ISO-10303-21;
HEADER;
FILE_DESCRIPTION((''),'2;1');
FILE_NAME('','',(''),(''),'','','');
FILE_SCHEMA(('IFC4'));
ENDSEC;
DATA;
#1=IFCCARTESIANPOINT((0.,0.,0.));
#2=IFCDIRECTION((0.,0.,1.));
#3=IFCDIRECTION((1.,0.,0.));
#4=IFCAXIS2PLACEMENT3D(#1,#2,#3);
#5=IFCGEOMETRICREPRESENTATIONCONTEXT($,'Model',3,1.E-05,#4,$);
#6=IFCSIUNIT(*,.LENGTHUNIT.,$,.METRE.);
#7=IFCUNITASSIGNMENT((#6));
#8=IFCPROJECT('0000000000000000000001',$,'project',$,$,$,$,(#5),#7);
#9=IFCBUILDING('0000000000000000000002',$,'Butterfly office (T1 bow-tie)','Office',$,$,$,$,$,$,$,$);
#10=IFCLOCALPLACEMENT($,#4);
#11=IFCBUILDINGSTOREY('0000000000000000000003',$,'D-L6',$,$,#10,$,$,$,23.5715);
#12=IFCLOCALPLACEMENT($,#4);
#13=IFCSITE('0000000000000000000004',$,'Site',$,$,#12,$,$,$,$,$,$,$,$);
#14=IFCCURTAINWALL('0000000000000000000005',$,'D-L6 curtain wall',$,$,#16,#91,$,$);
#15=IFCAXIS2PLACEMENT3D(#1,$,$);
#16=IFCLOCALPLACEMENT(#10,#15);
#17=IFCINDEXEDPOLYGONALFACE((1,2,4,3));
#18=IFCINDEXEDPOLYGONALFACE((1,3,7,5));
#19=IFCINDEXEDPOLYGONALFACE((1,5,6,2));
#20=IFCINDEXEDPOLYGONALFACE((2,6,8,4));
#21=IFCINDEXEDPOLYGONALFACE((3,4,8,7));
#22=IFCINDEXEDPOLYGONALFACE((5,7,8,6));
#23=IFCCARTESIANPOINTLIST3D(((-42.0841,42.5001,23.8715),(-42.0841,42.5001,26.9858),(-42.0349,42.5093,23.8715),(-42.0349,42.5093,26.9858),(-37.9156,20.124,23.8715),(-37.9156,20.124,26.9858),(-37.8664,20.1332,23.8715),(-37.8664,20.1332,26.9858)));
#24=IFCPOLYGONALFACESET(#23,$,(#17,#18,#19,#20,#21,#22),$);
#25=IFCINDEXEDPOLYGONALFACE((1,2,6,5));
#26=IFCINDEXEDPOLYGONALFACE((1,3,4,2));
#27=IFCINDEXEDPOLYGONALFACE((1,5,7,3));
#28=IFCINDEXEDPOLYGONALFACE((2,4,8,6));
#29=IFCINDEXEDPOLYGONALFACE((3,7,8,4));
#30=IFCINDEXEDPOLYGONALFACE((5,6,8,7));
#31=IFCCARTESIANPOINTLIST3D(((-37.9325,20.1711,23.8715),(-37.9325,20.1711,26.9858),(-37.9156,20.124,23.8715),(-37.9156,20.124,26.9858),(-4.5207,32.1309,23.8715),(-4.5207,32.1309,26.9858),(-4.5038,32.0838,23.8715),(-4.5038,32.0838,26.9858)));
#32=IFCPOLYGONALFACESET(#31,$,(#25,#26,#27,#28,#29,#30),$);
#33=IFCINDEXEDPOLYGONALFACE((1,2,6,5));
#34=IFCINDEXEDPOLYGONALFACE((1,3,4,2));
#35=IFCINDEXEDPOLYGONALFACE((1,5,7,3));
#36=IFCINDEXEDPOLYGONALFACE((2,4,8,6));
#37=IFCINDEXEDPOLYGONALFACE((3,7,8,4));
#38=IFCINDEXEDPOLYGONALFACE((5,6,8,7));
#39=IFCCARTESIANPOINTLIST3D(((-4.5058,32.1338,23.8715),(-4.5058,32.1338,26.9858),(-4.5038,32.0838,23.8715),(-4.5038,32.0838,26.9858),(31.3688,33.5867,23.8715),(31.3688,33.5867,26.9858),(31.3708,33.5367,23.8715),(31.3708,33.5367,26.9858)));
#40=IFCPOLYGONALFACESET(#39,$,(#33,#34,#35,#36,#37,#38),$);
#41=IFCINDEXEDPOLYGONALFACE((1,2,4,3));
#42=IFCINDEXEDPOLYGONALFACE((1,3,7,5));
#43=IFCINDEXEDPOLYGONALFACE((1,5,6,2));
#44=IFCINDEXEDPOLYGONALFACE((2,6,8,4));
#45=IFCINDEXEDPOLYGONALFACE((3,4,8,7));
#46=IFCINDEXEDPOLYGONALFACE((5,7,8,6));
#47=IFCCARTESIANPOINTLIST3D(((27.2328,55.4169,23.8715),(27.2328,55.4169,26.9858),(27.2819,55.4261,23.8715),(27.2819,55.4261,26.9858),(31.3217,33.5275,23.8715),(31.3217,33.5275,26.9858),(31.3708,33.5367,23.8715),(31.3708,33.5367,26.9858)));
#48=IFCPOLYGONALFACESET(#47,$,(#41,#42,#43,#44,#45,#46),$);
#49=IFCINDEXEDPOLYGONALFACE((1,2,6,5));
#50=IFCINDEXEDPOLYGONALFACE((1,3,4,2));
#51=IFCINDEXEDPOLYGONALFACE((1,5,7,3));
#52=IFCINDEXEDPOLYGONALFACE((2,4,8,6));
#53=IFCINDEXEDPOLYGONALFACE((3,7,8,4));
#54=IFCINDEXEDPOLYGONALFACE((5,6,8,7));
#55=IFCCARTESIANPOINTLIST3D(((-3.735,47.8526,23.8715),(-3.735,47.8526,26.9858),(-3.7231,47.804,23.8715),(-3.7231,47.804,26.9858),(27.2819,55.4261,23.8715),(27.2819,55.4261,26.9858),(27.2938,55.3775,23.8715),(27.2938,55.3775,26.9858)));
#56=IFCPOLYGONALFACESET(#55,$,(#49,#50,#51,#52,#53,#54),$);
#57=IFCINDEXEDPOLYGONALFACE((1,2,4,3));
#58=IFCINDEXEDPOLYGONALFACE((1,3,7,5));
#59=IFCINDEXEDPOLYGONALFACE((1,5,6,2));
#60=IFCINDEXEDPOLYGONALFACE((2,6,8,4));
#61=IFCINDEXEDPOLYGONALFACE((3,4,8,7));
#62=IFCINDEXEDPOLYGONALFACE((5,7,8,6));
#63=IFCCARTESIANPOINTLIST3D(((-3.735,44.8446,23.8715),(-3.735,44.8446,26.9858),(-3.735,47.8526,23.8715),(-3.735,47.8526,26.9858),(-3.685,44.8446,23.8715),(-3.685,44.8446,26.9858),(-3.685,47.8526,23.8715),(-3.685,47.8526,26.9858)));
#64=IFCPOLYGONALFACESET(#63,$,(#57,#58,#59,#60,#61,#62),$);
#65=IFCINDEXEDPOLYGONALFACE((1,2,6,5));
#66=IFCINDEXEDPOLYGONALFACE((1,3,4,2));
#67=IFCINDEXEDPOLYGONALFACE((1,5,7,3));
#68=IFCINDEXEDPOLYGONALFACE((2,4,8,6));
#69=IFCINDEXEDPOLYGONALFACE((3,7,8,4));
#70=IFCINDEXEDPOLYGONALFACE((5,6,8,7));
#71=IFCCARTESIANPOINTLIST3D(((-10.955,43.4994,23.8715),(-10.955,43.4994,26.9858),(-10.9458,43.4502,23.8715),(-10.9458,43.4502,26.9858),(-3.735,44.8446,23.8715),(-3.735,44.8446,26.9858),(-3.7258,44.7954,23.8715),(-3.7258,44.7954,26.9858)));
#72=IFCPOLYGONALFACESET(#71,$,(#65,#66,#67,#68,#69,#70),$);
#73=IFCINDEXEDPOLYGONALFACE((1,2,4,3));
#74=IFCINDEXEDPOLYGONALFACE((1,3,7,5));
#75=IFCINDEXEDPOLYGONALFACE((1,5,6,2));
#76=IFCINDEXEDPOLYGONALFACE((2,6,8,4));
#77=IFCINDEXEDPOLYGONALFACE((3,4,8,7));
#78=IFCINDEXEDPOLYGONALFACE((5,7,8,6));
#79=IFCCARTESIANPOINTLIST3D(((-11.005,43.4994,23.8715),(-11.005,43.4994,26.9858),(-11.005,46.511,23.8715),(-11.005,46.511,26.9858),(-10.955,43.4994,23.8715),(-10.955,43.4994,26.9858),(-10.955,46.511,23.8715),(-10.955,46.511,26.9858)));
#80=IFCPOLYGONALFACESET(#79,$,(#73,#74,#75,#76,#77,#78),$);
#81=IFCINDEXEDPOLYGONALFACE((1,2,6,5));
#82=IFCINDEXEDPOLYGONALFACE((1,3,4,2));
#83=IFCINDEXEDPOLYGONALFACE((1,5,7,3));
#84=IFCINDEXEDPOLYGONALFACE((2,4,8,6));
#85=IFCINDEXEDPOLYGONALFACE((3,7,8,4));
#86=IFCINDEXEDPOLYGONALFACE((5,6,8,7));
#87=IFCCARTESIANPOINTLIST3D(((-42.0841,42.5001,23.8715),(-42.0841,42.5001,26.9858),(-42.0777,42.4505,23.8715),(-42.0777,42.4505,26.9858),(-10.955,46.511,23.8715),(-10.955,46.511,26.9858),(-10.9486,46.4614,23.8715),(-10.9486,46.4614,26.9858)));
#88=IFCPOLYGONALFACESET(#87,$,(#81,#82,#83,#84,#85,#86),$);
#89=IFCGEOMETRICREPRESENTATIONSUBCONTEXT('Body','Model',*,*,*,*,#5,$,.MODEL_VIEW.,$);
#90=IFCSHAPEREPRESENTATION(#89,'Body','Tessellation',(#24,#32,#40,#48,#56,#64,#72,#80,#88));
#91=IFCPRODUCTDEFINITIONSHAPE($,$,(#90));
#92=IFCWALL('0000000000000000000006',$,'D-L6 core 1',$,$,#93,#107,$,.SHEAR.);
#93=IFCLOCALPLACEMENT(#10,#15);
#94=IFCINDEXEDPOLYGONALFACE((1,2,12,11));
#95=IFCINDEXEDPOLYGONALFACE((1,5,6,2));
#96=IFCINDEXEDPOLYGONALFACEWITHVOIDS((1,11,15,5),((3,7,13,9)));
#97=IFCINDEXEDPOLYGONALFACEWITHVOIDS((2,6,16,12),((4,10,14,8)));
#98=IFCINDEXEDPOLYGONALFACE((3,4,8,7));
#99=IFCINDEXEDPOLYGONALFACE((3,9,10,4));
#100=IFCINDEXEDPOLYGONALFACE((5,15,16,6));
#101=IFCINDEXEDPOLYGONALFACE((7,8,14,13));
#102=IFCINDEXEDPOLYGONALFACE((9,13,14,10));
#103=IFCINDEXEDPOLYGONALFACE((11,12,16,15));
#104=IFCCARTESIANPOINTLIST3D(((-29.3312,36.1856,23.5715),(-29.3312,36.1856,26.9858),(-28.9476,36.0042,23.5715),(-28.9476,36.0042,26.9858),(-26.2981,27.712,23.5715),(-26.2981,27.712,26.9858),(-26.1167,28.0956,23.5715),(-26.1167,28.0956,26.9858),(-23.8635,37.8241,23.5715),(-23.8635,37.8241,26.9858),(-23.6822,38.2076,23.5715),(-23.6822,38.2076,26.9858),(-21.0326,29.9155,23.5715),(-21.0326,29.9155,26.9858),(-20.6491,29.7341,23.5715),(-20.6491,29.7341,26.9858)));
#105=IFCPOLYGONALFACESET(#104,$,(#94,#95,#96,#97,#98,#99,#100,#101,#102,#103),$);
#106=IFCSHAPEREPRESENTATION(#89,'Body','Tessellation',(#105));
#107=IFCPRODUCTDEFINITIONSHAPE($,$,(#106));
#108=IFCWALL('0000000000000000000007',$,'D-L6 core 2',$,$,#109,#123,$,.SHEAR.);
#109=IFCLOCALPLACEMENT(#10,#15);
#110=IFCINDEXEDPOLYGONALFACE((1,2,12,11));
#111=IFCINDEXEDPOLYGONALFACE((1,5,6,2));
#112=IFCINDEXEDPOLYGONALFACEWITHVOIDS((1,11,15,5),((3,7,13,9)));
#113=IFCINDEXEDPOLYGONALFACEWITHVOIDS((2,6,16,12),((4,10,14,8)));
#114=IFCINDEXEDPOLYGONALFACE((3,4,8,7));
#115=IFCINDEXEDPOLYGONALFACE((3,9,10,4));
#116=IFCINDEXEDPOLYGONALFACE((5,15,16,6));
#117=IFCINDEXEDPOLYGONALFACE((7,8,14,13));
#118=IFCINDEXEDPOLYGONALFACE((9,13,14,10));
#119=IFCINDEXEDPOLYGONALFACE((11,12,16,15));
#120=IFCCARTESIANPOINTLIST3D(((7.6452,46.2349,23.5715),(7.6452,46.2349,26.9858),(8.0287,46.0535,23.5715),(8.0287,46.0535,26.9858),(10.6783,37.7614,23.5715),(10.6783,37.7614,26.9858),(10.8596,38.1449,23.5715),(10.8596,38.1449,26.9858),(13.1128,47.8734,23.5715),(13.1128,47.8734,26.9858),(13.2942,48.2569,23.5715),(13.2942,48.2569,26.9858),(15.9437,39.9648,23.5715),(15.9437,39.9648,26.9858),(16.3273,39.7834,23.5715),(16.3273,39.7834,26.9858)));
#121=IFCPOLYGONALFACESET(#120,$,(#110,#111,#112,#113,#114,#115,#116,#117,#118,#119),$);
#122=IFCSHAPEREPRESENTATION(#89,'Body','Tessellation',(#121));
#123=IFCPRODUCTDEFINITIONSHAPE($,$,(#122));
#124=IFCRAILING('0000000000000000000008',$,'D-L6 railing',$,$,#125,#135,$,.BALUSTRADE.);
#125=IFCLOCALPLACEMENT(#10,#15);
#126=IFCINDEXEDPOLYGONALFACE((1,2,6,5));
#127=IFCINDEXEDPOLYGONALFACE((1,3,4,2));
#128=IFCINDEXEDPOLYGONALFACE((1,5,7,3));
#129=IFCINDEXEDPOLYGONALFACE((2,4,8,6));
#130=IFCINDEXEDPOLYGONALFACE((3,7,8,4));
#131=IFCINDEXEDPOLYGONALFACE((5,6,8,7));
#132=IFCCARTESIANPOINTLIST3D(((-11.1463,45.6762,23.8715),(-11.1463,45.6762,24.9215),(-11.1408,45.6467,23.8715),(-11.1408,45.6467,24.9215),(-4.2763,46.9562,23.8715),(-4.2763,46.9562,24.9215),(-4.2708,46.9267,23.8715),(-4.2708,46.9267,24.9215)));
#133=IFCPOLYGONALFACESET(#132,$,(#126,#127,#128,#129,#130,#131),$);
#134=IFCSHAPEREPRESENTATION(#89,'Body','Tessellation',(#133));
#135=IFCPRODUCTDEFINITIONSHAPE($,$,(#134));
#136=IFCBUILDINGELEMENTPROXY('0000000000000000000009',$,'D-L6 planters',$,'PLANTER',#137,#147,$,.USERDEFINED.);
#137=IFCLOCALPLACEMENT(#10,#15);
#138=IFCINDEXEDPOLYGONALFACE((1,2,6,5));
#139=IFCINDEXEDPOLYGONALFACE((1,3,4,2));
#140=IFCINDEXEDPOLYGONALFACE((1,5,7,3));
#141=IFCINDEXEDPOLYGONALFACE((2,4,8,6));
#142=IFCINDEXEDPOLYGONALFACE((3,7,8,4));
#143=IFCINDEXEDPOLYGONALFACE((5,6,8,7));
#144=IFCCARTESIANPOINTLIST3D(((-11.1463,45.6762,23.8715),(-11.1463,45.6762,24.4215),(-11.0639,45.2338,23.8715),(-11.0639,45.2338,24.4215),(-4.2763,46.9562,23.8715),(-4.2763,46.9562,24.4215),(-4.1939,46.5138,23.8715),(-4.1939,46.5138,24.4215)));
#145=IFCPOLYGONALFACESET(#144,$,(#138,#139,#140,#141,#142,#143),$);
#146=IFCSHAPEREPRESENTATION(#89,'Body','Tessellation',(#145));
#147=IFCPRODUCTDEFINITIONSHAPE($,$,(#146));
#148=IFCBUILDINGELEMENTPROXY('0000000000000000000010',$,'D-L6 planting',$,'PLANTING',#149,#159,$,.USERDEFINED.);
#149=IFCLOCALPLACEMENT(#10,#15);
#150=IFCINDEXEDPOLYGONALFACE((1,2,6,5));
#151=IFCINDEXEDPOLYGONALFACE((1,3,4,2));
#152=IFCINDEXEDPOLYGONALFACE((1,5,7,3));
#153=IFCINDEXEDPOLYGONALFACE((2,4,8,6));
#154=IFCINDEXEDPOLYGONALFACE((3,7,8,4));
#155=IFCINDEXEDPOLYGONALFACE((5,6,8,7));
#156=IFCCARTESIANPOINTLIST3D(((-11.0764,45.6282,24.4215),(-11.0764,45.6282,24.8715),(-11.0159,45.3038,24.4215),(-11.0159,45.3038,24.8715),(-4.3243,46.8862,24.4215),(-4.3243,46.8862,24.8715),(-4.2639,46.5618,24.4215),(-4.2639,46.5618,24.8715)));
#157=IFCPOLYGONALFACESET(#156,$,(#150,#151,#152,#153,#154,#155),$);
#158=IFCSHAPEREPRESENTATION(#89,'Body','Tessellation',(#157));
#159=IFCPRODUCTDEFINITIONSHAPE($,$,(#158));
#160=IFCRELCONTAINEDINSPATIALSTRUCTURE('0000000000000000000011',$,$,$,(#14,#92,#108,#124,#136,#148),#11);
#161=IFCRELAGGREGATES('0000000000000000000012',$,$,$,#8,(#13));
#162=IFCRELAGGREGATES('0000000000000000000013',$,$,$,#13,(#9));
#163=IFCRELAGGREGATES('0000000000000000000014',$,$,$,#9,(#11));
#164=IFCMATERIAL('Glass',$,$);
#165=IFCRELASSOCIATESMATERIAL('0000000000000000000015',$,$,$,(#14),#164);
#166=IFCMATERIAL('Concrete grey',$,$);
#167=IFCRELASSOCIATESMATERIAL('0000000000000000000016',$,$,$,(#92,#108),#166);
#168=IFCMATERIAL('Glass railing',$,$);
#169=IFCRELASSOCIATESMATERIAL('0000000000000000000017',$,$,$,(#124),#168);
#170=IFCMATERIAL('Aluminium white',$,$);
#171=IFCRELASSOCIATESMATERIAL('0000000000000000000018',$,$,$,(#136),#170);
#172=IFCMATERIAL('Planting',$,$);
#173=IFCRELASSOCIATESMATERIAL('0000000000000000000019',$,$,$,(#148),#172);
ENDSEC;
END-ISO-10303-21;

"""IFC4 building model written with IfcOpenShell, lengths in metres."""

from ifc_helpers import new_model, si_unit, frame, origin_with_axes, place, context, subcontext, project, spatial, polyline, outline, extrude, material, element, save


model = new_model("IFC4")

# Units and contexts
model_context = context("Model", 3, precision=1e-05, world=origin_with_axes())
body_context = subcontext(model_context, "Body", "Model", "MODEL_VIEW")
ifc_project = project(units=[si_unit("LENGTHUNIT", "METRE")], contexts=[model_context])

# Site, building, storey
site_placement = place(None, origin_with_axes())
site = spatial("IfcSite", under=ifc_project, at=site_placement, Name="Site")
building = spatial("IfcBuilding", under=site, Name="Butterfly office (T1 bow-tie)", Description="Office")
storey_placement = place(None, origin_with_axes())
storey = spatial("IfcBuildingStorey", under=building, at=storey_placement, Name="D-L6", Elevation=23.5715)

# Shared definitions
ifc_material_1 = material(Name="Concrete grey")

# Shared definitions
ifc_material_2 = material(Name="Aluminium white")

# Curtain wall
ifc_material_3 = material(Name="Glass")
curtain_wall_placement = place(storey_placement, origin_with_axes())
element("IfcCurtainWall", 1, at=curtain_wall_placement, inside=storey, material=ifc_material_3, Name="D-L6 curtain wall", context=body_context, shape_type="SweptSolid", body=[
    extrude(outline(polyline([(-42.0841, 42.5001), (-37.9156, 20.124), (-37.8664, 20.1332), (-42.0349, 42.5093), (-42.0841, 42.5001)])), frame((0.0, 0.0, 23.8715), z_axis=(0.0, 0.0, 1.0), x_axis=(1.0, 0.0, 0.0)), (0.0, 0.0, 1.0), 3.1143),
    extrude(outline(polyline([(-37.9156, 20.124), (-4.5038, 32.0838), (-4.5207, 32.1309), (-37.9325, 20.1711), (-37.9156, 20.124)])), frame((0.0, 0.0, 23.8715), z_axis=(0.0, 0.0, 1.0), x_axis=(1.0, 0.0, 0.0)), (0.0, 0.0, 1.0), 3.1143),
    extrude(outline(polyline([(-4.5038, 32.0838), (31.3708, 33.5367), (31.3688, 33.5867), (-4.5058, 32.1338), (-4.5038, 32.0838)])), frame((0.0, 0.0, 23.8715), z_axis=(0.0, 0.0, 1.0), x_axis=(1.0, 0.0, 0.0)), (0.0, 0.0, 1.0), 3.1143),
    extrude(outline(polyline([(31.3708, 33.5367), (27.2819, 55.4261), (27.2328, 55.4169), (31.3217, 33.5275), (31.3708, 33.5367)])), frame((0.0, 0.0, 23.8715), z_axis=(0.0, 0.0, 1.0), x_axis=(1.0, 0.0, 0.0)), (0.0, 0.0, 1.0), 3.1143),
    extrude(outline(polyline([(27.2819, 55.4261), (-3.735, 47.8526), (-3.7231, 47.804), (27.2938, 55.3775), (27.2819, 55.4261)])), frame((0.0, 0.0, 23.8715), z_axis=(0.0, 0.0, 1.0), x_axis=(1.0, 0.0, 0.0)), (0.0, 0.0, 1.0), 3.1143),
    extrude(outline(polyline([(-3.735, 47.8526), (-3.735, 44.8446), (-3.685, 44.8446), (-3.685, 47.8526), (-3.735, 47.8526)])), frame((0.0, 0.0, 23.8715), z_axis=(0.0, 0.0, 1.0), x_axis=(1.0, 0.0, 0.0)), (0.0, 0.0, 1.0), 3.1143),
    extrude(outline(polyline([(-3.735, 44.8446), (-10.955, 43.4994), (-10.9458, 43.4502), (-3.7258, 44.7954), (-3.735, 44.8446)])), frame((0.0, 0.0, 23.8715), z_axis=(0.0, 0.0, 1.0), x_axis=(1.0, 0.0, 0.0)), (0.0, 0.0, 1.0), 3.1143),
    extrude(outline(polyline([(-10.955, 43.4994), (-10.955, 46.511), (-11.005, 46.511), (-11.005, 43.4994), (-10.955, 43.4994)])), frame((0.0, 0.0, 23.8715), z_axis=(0.0, 0.0, 1.0), x_axis=(1.0, 0.0, 0.0)), (0.0, 0.0, 1.0), 3.1143),
    extrude(outline(polyline([(-10.955, 46.511), (-42.0841, 42.5001), (-42.0777, 42.4505), (-10.9486, 46.4614), (-10.955, 46.511)])), frame((0.0, 0.0, 23.8715), z_axis=(0.0, 0.0, 1.0), x_axis=(1.0, 0.0, 0.0)), (0.0, 0.0, 1.0), 3.1143),
])

# Walls
wall_1_placement = place(storey_placement, origin_with_axes())
element("IfcWall", 2, at=wall_1_placement, inside=storey, material=ifc_material_1, Name="D-L6 core 1", PredefinedType="SHEAR", context=body_context, shape_type="SweptSolid", body=[
    extrude(outline(polyline([(-26.2981, 27.712), (-20.6491, 29.7341), (-23.6822, 38.2076), (-29.3312, 36.1856), (-26.2981, 27.712)]), holes=[polyline([(-26.1167, 28.0956), (-21.0326, 29.9155), (-23.8635, 37.8241), (-28.9476, 36.0042), (-26.1167, 28.0956)])]), frame((0.0, 0.0, 23.5715), z_axis=(0.0, 0.0, 1.0), x_axis=(1.0, 0.0, 0.0)), (0.0, 0.0, 1.0), 3.4143),
])
wall_2_placement = place(storey_placement, origin_with_axes())
element("IfcWall", 3, at=wall_2_placement, inside=storey, material=ifc_material_1, Name="D-L6 core 2", PredefinedType="SHEAR", context=body_context, shape_type="SweptSolid", body=[
    extrude(outline(polyline([(10.6783, 37.7614), (16.3273, 39.7834), (13.2942, 48.2569), (7.6452, 46.2349), (10.6783, 37.7614)]), holes=[polyline([(10.8596, 38.1449), (15.9437, 39.9648), (13.1128, 47.8734), (8.0287, 46.0535), (10.8596, 38.1449)])]), frame((0.0, 0.0, 23.5715), z_axis=(0.0, 0.0, 1.0), x_axis=(1.0, 0.0, 0.0)), (0.0, 0.0, 1.0), 3.4143),
])

# Railing
ifc_material_4 = material(Name="Glass railing")
railing_placement = place(storey_placement, origin_with_axes())
element("IfcRailing", 4, at=railing_placement, inside=storey, material=ifc_material_4, Name="D-L6 railing", PredefinedType="BALUSTRADE", context=body_context, shape_type="SweptSolid", body=[
    extrude(outline(polyline([(-4.2763, 46.9562), (-11.1463, 45.6762), (-11.1408, 45.6467), (-4.2708, 46.9267), (-4.2763, 46.9562)])), frame((0.0, 0.0, 23.8715), z_axis=(0.0, 0.0, 1.0), x_axis=(1.0, 0.0, 0.0)), (0.0, 0.0, 1.0), 1.05),
])

# Building element proxies
proxy_1_placement = place(storey_placement, origin_with_axes())
element("IfcBuildingElementProxy", 5, at=proxy_1_placement, inside=storey, material=ifc_material_2, Name="D-L6 planters", ObjectType="PLANTER", PredefinedType="USERDEFINED", context=body_context, shape_type="SweptSolid", body=[
    extrude(outline(polyline([(-4.2763, 46.9562), (-11.1463, 45.6762), (-11.0639, 45.2338), (-4.1939, 46.5138), (-4.2763, 46.9562)])), frame((0.0, 0.0, 23.8715), z_axis=(0.0, 0.0, 1.0), x_axis=(1.0, 0.0, 0.0)), (0.0, 0.0, 1.0), 0.55),
])
ifc_material_5 = material(Name="Planting")
proxy_2_placement = place(storey_placement, origin_with_axes())
element("IfcBuildingElementProxy", 6, at=proxy_2_placement, inside=storey, material=ifc_material_5, Name="D-L6 planting", ObjectType="PLANTING", PredefinedType="USERDEFINED", context=body_context, shape_type="SweptSolid", body=[
    extrude(outline(polyline([(-4.3243, 46.8862), (-11.0764, 45.6282), (-11.0159, 45.3038), (-4.2639, 46.5618), (-4.3243, 46.8862)])), frame((0.0, 0.0, 24.4215), z_axis=(0.0, 0.0, 1.0), x_axis=(1.0, 0.0, 0.0)), (0.0, 0.0, 1.0), 0.45),
])

save(model, "model.ifc")
